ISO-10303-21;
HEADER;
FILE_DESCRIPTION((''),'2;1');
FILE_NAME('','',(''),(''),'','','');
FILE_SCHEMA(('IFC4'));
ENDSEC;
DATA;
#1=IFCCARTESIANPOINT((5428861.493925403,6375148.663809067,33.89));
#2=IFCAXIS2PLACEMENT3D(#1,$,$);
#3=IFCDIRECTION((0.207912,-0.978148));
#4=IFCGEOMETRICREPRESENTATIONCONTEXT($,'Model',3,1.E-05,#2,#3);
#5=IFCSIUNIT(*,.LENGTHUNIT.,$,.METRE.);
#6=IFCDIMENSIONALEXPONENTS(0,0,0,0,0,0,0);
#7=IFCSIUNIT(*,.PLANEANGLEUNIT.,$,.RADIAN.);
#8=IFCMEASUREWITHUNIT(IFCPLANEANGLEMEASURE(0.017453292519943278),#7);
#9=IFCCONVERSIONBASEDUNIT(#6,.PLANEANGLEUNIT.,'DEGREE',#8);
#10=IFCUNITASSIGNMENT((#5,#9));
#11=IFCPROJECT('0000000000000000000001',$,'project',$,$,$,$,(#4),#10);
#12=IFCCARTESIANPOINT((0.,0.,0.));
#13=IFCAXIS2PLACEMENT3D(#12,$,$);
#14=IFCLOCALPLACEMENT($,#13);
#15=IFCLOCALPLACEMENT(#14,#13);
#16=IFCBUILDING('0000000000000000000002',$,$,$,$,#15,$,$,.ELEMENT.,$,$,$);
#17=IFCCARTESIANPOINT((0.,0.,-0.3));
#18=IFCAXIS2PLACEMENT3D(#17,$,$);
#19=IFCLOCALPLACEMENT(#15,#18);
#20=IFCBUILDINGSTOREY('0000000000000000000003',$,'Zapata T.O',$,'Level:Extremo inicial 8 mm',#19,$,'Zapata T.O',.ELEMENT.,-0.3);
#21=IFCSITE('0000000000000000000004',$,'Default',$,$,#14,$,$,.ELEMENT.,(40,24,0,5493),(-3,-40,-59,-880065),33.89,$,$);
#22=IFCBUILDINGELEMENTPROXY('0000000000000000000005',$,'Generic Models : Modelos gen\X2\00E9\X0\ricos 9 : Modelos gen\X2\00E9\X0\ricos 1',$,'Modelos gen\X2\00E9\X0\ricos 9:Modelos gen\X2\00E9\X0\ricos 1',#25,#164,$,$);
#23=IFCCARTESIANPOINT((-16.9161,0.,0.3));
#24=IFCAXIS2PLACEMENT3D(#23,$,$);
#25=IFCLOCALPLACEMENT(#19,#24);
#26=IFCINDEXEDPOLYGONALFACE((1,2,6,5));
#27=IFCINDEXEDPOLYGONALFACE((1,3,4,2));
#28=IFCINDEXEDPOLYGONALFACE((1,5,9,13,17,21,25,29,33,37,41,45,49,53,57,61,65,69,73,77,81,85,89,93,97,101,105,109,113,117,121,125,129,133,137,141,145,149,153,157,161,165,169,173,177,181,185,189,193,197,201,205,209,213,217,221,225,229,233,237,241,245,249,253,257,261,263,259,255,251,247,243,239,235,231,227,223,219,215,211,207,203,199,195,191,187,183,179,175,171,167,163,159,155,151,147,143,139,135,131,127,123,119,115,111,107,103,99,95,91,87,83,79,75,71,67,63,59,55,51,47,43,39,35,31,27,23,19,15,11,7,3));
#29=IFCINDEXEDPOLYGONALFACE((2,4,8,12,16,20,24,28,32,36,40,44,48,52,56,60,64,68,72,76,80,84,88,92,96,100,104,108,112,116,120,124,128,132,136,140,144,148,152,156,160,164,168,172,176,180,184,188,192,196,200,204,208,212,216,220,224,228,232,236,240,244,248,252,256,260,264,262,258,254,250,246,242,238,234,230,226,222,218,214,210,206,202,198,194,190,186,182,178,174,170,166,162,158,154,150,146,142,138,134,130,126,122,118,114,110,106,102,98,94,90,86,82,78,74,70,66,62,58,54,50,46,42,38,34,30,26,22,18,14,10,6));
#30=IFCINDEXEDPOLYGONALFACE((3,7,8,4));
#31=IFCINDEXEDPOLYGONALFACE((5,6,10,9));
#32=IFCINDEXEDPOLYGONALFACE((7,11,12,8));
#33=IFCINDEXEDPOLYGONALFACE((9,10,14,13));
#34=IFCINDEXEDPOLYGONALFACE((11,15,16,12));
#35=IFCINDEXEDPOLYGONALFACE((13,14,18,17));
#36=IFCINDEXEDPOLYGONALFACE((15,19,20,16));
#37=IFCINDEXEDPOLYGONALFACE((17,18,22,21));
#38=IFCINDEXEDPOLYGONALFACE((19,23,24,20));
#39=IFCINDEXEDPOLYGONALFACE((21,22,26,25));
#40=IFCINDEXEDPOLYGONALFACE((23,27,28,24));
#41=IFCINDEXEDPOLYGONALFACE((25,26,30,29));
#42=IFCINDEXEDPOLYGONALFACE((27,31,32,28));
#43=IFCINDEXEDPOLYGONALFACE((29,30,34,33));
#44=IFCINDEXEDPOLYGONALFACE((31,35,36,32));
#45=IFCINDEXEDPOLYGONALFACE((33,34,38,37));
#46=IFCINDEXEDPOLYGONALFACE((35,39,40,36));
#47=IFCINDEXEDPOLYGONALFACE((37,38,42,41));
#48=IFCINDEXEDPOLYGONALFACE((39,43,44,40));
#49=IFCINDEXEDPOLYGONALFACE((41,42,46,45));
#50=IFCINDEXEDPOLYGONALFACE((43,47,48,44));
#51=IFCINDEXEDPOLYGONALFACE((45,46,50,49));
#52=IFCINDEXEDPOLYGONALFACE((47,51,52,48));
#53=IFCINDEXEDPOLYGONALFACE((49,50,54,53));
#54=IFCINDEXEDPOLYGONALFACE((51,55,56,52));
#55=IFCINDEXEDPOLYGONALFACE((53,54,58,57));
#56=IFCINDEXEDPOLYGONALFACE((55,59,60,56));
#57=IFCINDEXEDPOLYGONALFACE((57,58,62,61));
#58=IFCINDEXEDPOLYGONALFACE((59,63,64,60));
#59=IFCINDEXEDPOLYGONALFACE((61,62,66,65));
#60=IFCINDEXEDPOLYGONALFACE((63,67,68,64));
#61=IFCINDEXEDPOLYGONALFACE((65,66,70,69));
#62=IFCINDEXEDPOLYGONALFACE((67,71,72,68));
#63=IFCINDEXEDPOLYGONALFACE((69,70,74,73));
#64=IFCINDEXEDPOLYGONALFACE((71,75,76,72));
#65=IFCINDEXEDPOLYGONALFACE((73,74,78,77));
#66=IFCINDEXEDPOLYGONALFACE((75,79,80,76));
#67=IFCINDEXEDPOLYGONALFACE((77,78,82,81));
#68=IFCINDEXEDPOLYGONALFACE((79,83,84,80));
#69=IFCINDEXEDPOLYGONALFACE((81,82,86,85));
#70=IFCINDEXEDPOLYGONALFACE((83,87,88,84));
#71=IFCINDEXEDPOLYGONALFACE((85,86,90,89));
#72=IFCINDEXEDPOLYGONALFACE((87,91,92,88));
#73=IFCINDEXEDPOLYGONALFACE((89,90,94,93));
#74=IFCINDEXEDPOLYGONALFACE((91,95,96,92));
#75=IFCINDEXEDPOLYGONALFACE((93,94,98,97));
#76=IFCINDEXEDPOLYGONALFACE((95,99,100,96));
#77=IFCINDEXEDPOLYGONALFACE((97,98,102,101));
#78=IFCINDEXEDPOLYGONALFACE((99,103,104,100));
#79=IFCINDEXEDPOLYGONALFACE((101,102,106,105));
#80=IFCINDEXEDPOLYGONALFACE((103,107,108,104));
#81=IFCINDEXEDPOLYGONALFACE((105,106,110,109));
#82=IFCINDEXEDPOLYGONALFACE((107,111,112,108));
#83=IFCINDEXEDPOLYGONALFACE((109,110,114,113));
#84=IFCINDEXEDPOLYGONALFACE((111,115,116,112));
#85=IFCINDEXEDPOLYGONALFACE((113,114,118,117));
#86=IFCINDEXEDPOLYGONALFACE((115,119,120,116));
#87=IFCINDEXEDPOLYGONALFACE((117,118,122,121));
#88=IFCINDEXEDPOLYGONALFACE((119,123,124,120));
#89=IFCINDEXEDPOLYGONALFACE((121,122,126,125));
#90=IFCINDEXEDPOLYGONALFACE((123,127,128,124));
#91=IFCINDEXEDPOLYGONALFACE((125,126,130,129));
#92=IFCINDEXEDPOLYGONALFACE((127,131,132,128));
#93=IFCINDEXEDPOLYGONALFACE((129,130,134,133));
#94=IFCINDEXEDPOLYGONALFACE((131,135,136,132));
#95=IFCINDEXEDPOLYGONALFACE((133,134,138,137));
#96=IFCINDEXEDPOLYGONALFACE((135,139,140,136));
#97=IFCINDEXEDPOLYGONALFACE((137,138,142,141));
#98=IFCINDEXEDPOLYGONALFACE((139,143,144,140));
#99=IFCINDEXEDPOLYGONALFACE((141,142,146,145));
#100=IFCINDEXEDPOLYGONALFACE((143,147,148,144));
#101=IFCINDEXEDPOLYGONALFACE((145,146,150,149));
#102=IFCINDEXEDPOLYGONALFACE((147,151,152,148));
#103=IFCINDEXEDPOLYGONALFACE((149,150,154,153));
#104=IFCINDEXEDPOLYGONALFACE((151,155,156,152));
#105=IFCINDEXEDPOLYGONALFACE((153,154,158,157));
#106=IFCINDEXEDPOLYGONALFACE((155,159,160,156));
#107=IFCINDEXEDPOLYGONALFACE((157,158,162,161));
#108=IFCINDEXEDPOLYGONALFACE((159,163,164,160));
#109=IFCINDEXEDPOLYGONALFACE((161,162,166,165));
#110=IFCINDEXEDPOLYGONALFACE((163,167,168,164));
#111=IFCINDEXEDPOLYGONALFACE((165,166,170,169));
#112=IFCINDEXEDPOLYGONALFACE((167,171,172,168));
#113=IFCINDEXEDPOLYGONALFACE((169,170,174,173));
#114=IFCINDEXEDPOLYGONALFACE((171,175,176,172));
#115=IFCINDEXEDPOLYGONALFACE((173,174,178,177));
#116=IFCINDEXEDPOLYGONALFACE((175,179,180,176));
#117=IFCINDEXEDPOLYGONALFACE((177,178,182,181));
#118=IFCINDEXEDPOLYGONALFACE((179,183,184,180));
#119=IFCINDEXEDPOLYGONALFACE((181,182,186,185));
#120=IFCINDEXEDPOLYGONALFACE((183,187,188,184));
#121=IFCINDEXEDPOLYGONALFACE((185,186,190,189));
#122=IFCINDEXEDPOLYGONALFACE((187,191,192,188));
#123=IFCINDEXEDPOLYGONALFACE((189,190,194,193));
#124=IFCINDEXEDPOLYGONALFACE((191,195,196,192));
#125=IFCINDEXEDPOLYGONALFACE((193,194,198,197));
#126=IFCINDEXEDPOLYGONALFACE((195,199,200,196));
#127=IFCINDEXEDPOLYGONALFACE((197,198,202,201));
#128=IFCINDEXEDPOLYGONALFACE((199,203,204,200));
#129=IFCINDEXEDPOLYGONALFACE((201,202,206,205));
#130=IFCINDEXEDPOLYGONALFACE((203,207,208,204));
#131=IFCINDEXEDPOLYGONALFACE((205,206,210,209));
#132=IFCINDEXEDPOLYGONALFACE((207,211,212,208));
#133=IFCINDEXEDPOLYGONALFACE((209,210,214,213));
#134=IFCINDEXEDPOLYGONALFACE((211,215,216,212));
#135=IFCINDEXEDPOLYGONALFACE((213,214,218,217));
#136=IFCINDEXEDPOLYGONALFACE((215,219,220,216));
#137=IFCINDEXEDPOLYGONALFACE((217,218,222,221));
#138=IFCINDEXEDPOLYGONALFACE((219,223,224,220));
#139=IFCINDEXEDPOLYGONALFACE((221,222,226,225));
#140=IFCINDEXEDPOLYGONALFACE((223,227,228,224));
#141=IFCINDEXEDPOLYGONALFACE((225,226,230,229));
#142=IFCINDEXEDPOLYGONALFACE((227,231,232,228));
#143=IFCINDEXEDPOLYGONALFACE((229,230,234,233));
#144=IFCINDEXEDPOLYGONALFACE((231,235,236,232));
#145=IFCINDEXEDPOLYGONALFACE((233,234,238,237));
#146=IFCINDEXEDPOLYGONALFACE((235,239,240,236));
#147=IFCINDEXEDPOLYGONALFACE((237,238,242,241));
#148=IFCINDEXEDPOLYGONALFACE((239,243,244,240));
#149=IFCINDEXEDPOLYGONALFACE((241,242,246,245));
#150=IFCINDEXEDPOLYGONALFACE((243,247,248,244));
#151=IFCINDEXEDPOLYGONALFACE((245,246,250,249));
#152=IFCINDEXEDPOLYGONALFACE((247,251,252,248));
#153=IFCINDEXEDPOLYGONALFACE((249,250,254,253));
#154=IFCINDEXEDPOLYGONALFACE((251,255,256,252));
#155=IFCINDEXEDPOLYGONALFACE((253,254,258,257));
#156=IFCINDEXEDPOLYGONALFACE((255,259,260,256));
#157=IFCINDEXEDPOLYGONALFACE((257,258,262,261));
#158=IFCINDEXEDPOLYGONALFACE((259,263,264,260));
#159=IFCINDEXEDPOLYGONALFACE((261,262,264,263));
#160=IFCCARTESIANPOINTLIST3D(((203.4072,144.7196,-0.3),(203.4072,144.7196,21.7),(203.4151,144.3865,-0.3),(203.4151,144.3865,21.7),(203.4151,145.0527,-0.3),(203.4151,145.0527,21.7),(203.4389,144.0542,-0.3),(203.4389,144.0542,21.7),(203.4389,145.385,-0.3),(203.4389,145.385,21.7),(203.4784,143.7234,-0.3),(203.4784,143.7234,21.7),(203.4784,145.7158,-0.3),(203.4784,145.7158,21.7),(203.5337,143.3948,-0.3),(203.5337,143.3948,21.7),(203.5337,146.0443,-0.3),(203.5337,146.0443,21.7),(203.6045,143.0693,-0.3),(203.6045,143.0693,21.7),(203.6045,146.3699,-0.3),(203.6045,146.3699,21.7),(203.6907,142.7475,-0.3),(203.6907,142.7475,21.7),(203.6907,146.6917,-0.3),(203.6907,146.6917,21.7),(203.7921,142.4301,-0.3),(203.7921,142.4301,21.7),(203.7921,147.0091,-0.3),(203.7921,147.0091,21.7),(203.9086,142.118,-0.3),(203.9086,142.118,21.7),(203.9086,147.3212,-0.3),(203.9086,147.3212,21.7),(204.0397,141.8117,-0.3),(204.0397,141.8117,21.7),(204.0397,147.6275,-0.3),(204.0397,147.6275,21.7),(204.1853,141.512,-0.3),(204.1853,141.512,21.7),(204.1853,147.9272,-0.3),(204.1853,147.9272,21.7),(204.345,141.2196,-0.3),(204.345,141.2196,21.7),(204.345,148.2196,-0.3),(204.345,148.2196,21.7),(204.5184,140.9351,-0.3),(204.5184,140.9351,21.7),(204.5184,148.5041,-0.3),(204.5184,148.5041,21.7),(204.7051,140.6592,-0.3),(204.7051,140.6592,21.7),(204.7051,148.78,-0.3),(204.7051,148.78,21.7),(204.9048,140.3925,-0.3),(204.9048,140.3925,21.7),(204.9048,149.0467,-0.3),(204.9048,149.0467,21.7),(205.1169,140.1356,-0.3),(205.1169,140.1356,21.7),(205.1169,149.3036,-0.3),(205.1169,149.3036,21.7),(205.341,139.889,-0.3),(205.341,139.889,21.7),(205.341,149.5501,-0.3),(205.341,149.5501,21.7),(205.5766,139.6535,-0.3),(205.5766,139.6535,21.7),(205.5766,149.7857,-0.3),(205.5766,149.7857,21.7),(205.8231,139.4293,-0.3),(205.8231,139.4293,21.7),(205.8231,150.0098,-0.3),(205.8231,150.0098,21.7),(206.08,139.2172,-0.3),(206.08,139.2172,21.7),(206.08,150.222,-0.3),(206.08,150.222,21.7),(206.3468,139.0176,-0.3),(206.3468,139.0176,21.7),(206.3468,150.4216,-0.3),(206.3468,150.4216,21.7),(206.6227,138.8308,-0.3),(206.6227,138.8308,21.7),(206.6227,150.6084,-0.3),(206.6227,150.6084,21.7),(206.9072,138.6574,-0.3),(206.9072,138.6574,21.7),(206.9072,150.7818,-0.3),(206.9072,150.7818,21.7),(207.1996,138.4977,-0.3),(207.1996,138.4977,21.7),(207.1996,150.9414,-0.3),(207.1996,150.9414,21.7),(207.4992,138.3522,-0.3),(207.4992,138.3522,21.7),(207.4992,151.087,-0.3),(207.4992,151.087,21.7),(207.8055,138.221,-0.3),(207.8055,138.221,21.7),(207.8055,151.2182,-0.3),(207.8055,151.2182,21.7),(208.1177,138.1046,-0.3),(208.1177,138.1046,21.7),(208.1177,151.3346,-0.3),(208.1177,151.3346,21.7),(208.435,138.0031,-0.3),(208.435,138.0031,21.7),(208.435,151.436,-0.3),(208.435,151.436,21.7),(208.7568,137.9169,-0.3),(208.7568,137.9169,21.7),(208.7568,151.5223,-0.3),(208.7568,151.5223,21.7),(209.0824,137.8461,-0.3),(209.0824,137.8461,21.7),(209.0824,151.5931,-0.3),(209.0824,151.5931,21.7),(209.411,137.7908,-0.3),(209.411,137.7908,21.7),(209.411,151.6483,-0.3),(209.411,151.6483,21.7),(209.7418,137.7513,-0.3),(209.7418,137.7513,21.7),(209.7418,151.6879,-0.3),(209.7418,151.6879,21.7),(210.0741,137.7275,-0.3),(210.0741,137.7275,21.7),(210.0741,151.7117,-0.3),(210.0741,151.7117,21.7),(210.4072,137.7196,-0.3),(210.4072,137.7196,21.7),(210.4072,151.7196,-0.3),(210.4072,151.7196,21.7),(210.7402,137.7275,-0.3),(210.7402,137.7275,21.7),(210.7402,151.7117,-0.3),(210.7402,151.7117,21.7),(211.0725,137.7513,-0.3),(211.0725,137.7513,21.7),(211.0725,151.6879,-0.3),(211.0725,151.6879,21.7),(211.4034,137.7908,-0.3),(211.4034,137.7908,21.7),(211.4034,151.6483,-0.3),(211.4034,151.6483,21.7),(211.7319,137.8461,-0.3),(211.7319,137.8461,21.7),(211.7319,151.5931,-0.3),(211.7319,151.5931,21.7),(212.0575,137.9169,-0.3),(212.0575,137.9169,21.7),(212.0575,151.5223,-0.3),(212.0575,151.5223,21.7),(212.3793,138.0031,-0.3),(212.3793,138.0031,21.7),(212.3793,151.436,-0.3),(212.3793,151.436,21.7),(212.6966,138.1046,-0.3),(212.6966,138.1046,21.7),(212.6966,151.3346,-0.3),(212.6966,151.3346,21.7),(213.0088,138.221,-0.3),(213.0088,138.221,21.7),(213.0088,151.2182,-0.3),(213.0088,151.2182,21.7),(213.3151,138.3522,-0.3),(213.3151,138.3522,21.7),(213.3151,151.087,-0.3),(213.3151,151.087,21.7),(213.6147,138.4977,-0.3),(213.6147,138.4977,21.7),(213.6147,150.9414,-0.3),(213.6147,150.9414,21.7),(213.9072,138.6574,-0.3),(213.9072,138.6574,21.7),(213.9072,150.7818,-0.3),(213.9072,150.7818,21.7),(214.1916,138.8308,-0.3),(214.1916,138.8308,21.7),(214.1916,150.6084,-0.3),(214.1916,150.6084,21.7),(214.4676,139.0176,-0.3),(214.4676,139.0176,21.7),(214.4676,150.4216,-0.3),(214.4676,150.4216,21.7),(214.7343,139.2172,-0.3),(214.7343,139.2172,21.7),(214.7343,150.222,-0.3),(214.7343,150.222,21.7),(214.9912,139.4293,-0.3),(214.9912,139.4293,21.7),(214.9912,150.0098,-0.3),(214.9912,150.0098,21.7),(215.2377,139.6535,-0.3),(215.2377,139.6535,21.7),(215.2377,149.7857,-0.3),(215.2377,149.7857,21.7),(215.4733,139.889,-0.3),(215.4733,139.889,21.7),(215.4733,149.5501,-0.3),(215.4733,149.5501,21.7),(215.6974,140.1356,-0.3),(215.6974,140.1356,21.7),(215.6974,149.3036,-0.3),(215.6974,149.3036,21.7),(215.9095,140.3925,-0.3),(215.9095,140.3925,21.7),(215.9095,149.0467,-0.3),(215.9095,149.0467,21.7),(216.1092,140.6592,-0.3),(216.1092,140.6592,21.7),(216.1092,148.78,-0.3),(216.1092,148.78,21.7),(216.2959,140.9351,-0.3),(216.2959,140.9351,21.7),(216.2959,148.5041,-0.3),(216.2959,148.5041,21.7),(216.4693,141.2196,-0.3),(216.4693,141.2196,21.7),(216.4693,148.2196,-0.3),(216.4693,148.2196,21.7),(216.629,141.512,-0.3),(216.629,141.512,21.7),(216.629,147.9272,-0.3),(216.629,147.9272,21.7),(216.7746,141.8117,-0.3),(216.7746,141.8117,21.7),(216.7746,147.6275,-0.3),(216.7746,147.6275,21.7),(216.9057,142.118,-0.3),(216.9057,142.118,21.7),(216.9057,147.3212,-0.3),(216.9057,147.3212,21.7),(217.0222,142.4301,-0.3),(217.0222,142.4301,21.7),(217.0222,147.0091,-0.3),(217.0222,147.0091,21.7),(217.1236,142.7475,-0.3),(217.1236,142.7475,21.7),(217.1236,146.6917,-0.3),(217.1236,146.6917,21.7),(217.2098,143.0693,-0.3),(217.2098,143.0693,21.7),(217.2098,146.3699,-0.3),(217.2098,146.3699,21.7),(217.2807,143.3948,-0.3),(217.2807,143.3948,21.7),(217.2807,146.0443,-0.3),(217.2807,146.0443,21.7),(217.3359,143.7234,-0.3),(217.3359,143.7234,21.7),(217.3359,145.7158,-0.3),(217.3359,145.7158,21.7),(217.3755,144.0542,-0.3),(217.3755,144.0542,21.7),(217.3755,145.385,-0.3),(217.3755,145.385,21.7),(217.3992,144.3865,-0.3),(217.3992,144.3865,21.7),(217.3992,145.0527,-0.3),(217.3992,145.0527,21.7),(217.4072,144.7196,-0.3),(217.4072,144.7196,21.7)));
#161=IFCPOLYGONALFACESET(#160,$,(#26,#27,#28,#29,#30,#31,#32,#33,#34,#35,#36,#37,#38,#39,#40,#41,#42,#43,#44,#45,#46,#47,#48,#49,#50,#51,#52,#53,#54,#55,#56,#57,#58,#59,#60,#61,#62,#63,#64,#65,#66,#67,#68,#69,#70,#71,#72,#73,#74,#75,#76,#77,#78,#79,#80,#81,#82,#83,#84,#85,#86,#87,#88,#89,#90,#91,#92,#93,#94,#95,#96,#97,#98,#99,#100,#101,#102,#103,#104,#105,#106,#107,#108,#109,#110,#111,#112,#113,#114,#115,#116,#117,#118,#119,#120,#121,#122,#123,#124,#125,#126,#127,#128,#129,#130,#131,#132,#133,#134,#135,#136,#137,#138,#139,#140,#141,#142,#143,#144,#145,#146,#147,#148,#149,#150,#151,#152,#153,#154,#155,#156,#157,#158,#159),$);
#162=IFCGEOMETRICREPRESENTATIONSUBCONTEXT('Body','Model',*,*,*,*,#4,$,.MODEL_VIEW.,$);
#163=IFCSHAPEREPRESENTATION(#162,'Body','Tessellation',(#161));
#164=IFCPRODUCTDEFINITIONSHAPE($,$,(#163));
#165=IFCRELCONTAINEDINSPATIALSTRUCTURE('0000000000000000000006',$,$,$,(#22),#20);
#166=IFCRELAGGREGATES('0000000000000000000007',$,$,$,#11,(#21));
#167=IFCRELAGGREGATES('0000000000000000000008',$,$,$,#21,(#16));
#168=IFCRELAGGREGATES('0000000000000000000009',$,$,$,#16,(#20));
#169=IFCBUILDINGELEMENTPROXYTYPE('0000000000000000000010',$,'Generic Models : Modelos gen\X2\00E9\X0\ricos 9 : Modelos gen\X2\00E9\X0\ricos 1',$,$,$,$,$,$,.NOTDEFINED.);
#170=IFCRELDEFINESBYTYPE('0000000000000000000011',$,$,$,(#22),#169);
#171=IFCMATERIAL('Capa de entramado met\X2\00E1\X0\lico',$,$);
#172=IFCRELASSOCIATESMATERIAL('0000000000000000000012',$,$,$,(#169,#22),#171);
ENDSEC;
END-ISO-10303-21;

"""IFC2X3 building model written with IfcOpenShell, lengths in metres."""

from ifc_helpers import new_model, entity, si_unit, converted_unit, direction, frame, frame_2d, origin, place, context, subcontext, project, spatial, circle, extrude, source, transform, mapped, material, type_object, type_shapes, element, save


model = new_model("IFC2X3")

# Units and contexts
model_context = context("Model", 3, precision=1e-05, world=frame((5428861.493925403, 6375148.663809067, 33.89)), true_north=direction((0.207912, -0.978148)))
body_context = subcontext(model_context, "Body", "Model", "MODEL_VIEW")
ifc_project = project(units=[si_unit("LENGTHUNIT", "METRE"), converted_unit("PLANEANGLEUNIT", "DEGREE", entity("IfcPlaneAngleMeasure", 0.017453292519943278), si_unit("PLANEANGLEUNIT", "RADIAN"), dimensions=[0, 0, 0, 0, 0, 0, 0])], contexts=[model_context])

# Site, building, storey
site_placement = place(None, origin())
site = spatial("IfcSite", under=ifc_project, at=site_placement, Name="Default", CompositionType="ELEMENT", RefLatitude=(40, 24, 0, 5493), RefLongitude=(-3, -40, -59, -880065), RefElevation=33.89)
building_placement = place(site_placement, origin())
building = spatial("IfcBuilding", under=site, at=building_placement, CompositionType="ELEMENT")
storey_placement = place(building_placement, frame((0.0, 0.0, -0.3)))
storey = spatial("IfcBuildingStorey", under=building, at=storey_placement, Name="Zapata T.O", ObjectType="Level:Extremo inicial 8 mm", LongName="Zapata T.O", CompositionType="ELEMENT", Elevation=-0.3)

# Building element proxy
ifc_material = material(Name="Capa de entramado metálico")
building_element_proxy_type_1 = type_object("IfcBuildingElementProxyType", Name="Generic Models : Modelos genéricos 9 : Modelos genéricos 1", PredefinedType="NOTDEFINED", material=ifc_material)
shared_shape_1 = source(origin(), body_context, "Body", "SweptSolid", [
    extrude(circle(Radius=7.0, at=frame_2d((0.0, 0.0), x_axis=(1.0, 0.0))), frame((210.4072, 144.7196, -0.3)), (0.0, 0.0, 1.0), 22.0),
])
type_shapes(building_element_proxy_type_1, [shared_shape_1])
proxy_1_placement = place(storey_placement, frame((-16.9161, 0.0, 0.3)))
element("IfcBuildingElementProxy", 1, at=proxy_1_placement, inside=storey, type_object=building_element_proxy_type_1, material=ifc_material, Name="Generic Models : Modelos genéricos 9 : Modelos genéricos 1", ObjectType="Modelos genéricos 9:Modelos genéricos 1", context=body_context, shape_type="MappedRepresentation", body=[
    mapped(shared_shape_1, transform((0.0, 0.0, 0.0), scale=1.0)),
])

save(model, "model.ifc")
